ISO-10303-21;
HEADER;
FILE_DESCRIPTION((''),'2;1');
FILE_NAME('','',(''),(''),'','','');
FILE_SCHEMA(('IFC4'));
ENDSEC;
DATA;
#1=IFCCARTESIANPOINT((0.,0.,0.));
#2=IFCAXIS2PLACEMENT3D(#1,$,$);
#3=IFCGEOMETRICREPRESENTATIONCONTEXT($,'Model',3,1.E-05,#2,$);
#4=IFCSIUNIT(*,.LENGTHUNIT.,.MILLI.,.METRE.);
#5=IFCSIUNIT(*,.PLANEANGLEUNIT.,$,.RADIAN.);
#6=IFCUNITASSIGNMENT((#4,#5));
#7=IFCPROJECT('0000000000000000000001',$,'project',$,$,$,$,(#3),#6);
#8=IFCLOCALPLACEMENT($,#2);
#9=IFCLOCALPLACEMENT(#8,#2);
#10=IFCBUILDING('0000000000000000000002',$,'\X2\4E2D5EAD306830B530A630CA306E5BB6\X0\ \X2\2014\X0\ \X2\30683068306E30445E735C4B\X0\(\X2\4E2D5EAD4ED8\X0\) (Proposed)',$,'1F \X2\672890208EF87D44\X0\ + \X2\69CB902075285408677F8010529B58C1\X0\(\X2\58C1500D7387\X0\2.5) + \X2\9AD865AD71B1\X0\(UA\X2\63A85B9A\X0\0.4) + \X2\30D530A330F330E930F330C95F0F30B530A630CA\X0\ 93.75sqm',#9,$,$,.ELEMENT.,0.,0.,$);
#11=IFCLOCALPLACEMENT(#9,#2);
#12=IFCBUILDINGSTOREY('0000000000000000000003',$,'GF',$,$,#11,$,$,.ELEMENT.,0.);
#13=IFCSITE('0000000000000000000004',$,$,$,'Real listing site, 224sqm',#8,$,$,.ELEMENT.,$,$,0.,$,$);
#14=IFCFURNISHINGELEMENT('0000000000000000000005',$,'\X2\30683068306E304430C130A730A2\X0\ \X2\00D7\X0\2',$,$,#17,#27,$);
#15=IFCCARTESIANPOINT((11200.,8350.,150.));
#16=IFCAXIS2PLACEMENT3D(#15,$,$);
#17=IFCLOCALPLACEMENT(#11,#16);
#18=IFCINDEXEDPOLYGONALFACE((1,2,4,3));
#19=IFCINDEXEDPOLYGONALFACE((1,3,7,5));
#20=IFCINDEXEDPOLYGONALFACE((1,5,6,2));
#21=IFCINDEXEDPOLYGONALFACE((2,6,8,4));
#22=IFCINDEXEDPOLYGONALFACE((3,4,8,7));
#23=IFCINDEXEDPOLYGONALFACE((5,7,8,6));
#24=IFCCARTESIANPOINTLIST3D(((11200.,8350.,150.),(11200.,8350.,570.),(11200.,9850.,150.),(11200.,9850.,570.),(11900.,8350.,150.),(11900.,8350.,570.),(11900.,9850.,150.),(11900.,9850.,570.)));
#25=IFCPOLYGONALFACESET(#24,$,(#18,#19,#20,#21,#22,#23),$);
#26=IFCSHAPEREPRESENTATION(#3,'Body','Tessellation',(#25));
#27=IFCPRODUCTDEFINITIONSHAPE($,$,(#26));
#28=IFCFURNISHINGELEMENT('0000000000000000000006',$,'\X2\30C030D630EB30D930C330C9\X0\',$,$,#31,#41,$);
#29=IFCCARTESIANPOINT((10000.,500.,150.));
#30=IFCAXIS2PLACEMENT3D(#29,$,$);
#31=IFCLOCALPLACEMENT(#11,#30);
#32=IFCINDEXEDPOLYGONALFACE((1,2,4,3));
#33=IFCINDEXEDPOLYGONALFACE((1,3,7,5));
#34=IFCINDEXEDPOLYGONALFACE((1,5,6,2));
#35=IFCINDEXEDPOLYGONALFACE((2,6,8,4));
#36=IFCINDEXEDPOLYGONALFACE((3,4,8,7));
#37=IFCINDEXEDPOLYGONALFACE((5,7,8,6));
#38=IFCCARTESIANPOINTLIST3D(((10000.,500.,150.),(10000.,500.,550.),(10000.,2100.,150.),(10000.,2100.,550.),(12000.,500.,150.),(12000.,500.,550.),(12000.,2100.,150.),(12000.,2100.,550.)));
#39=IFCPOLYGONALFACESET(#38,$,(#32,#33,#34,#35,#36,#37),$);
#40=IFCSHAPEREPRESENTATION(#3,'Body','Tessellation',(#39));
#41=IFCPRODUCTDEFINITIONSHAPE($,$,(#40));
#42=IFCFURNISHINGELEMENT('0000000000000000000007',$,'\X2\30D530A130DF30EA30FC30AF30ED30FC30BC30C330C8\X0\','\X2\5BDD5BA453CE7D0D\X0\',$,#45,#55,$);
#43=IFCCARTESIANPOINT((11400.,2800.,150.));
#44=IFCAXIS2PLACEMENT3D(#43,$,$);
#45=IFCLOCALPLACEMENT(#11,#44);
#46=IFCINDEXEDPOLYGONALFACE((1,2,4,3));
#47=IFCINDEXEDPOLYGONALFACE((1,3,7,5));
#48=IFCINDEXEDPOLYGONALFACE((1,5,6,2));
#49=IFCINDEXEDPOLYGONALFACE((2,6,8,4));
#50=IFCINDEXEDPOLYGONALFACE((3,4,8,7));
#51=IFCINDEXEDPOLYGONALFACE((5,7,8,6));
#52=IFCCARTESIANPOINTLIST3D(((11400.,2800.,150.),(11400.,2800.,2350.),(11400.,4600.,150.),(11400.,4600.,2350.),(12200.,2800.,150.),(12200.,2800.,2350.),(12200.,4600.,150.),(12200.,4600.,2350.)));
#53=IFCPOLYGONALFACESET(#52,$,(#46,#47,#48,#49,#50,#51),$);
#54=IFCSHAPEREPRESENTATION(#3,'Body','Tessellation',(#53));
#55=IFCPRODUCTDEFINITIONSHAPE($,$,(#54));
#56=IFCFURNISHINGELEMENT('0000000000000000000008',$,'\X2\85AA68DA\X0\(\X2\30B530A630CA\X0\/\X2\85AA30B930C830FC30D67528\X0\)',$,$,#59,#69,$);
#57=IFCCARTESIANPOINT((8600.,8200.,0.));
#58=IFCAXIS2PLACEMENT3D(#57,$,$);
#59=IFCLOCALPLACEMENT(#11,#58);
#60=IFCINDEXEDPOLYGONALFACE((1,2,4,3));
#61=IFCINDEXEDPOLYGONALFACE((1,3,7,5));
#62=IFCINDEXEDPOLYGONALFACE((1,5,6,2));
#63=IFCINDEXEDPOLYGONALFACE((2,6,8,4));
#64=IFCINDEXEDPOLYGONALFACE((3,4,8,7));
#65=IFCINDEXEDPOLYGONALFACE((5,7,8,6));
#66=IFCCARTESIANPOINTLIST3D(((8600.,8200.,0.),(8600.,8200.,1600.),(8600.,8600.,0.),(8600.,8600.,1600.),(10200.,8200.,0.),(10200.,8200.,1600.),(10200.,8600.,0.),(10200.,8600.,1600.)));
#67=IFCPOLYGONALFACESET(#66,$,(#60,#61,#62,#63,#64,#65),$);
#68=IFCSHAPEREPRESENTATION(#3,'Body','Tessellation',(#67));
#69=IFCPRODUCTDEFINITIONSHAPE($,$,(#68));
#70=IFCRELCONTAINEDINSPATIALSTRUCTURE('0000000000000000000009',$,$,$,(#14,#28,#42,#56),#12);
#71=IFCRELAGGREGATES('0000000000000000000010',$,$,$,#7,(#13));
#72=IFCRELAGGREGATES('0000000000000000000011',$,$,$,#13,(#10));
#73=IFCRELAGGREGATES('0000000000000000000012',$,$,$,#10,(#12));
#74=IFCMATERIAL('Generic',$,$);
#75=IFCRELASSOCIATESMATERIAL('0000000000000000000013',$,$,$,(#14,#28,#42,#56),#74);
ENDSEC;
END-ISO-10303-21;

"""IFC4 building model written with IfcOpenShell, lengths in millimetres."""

from ifc_helpers import new_model, si_unit, frame, frame_2d, origin, place, context, project, spatial, rectangle, extrude, material, element, save


model = new_model("IFC4")

# Units and contexts
model_context = context("Model", 3, precision=1e-05, world=origin())
ifc_project = project(units=[si_unit("LENGTHUNIT", "METRE", prefix="MILLI"), si_unit("PLANEANGLEUNIT", "RADIAN")], contexts=[model_context])

# Site, building, storey
site_placement = place(None, origin())
site = spatial("IfcSite", under=ifc_project, at=site_placement, ObjectType="Real listing site, 224sqm", CompositionType="ELEMENT", RefElevation=0.0)
building_placement = place(site_placement, origin())
building = spatial("IfcBuilding", under=site, at=building_placement, Name="中庭とサウナの家 — ととのい平屋(中庭付) (Proposed)", ObjectType="1F 木造軸組 + 構造用合板耐力壁(壁倍率2.5) + 高断熱(UA推定0.4) + フィンランド式サウナ 93.75sqm", CompositionType="ELEMENT", ElevationOfRefHeight=0.0, ElevationOfTerrain=0.0)
storey_placement = place(building_placement, origin())
storey = spatial("IfcBuildingStorey", under=building, at=storey_placement, Name="GF", CompositionType="ELEMENT", Elevation=0.0)

# Shared definitions
ifc_material = material(Name="Generic")

# Furnishing elements
furnishing_1_placement = place(storey_placement, frame((11200.0, 8350.0, 150.0)))
element("IfcFurnishingElement", 1, at=furnishing_1_placement, inside=storey, material=ifc_material, Name="ととのいチェア ×2", context=model_context, shape_type="SweptSolid", body=[
    extrude(rectangle(XDim=700.0, YDim=1500.0, at=frame_2d((350.0, 750.0))), frame((11200.0, 8350.0, 150.0)), (0.0, 0.0, 1.0), 420.0),
])
furnishing_2_placement = place(storey_placement, frame((10000.0, 500.0, 150.0)))
element("IfcFurnishingElement", 2, at=furnishing_2_placement, inside=storey, material=ifc_material, Name="ダブルベッド", context=model_context, shape_type="SweptSolid", body=[
    extrude(rectangle(XDim=2000.0, YDim=1600.0, at=frame_2d((1000.0, 800.0))), frame((10000.0, 500.0, 150.0)), (0.0, 0.0, 1.0), 400.0),
])
furnishing_3_placement = place(storey_placement, frame((11400.0, 2800.0, 150.0)))
element("IfcFurnishingElement", 3, at=furnishing_3_placement, inside=storey, material=ifc_material, Name="ファミリークローゼット", Description="寝室収納", context=model_context, shape_type="SweptSolid", body=[
    extrude(rectangle(XDim=800.0, YDim=1800.0, at=frame_2d((400.0, 900.0))), frame((11400.0, 2800.0, 150.0)), (0.0, 0.0, 1.0), 2200.0),
])
furnishing_4_placement = place(storey_placement, frame((8600.0, 8200.0, 0.0)))
element("IfcFurnishingElement", 4, at=furnishing_4_placement, inside=storey, material=ifc_material, Name="薪棚(サウナ/薪ストーブ用)", context=model_context, shape_type="SweptSolid", body=[
    extrude(rectangle(XDim=1600.0, YDim=400.0, at=frame_2d((800.0, 200.0))), frame((8600.0, 8200.0, 0.0)), (0.0, 0.0, 1.0), 1600.0),
])

save(model, "model.ifc")
